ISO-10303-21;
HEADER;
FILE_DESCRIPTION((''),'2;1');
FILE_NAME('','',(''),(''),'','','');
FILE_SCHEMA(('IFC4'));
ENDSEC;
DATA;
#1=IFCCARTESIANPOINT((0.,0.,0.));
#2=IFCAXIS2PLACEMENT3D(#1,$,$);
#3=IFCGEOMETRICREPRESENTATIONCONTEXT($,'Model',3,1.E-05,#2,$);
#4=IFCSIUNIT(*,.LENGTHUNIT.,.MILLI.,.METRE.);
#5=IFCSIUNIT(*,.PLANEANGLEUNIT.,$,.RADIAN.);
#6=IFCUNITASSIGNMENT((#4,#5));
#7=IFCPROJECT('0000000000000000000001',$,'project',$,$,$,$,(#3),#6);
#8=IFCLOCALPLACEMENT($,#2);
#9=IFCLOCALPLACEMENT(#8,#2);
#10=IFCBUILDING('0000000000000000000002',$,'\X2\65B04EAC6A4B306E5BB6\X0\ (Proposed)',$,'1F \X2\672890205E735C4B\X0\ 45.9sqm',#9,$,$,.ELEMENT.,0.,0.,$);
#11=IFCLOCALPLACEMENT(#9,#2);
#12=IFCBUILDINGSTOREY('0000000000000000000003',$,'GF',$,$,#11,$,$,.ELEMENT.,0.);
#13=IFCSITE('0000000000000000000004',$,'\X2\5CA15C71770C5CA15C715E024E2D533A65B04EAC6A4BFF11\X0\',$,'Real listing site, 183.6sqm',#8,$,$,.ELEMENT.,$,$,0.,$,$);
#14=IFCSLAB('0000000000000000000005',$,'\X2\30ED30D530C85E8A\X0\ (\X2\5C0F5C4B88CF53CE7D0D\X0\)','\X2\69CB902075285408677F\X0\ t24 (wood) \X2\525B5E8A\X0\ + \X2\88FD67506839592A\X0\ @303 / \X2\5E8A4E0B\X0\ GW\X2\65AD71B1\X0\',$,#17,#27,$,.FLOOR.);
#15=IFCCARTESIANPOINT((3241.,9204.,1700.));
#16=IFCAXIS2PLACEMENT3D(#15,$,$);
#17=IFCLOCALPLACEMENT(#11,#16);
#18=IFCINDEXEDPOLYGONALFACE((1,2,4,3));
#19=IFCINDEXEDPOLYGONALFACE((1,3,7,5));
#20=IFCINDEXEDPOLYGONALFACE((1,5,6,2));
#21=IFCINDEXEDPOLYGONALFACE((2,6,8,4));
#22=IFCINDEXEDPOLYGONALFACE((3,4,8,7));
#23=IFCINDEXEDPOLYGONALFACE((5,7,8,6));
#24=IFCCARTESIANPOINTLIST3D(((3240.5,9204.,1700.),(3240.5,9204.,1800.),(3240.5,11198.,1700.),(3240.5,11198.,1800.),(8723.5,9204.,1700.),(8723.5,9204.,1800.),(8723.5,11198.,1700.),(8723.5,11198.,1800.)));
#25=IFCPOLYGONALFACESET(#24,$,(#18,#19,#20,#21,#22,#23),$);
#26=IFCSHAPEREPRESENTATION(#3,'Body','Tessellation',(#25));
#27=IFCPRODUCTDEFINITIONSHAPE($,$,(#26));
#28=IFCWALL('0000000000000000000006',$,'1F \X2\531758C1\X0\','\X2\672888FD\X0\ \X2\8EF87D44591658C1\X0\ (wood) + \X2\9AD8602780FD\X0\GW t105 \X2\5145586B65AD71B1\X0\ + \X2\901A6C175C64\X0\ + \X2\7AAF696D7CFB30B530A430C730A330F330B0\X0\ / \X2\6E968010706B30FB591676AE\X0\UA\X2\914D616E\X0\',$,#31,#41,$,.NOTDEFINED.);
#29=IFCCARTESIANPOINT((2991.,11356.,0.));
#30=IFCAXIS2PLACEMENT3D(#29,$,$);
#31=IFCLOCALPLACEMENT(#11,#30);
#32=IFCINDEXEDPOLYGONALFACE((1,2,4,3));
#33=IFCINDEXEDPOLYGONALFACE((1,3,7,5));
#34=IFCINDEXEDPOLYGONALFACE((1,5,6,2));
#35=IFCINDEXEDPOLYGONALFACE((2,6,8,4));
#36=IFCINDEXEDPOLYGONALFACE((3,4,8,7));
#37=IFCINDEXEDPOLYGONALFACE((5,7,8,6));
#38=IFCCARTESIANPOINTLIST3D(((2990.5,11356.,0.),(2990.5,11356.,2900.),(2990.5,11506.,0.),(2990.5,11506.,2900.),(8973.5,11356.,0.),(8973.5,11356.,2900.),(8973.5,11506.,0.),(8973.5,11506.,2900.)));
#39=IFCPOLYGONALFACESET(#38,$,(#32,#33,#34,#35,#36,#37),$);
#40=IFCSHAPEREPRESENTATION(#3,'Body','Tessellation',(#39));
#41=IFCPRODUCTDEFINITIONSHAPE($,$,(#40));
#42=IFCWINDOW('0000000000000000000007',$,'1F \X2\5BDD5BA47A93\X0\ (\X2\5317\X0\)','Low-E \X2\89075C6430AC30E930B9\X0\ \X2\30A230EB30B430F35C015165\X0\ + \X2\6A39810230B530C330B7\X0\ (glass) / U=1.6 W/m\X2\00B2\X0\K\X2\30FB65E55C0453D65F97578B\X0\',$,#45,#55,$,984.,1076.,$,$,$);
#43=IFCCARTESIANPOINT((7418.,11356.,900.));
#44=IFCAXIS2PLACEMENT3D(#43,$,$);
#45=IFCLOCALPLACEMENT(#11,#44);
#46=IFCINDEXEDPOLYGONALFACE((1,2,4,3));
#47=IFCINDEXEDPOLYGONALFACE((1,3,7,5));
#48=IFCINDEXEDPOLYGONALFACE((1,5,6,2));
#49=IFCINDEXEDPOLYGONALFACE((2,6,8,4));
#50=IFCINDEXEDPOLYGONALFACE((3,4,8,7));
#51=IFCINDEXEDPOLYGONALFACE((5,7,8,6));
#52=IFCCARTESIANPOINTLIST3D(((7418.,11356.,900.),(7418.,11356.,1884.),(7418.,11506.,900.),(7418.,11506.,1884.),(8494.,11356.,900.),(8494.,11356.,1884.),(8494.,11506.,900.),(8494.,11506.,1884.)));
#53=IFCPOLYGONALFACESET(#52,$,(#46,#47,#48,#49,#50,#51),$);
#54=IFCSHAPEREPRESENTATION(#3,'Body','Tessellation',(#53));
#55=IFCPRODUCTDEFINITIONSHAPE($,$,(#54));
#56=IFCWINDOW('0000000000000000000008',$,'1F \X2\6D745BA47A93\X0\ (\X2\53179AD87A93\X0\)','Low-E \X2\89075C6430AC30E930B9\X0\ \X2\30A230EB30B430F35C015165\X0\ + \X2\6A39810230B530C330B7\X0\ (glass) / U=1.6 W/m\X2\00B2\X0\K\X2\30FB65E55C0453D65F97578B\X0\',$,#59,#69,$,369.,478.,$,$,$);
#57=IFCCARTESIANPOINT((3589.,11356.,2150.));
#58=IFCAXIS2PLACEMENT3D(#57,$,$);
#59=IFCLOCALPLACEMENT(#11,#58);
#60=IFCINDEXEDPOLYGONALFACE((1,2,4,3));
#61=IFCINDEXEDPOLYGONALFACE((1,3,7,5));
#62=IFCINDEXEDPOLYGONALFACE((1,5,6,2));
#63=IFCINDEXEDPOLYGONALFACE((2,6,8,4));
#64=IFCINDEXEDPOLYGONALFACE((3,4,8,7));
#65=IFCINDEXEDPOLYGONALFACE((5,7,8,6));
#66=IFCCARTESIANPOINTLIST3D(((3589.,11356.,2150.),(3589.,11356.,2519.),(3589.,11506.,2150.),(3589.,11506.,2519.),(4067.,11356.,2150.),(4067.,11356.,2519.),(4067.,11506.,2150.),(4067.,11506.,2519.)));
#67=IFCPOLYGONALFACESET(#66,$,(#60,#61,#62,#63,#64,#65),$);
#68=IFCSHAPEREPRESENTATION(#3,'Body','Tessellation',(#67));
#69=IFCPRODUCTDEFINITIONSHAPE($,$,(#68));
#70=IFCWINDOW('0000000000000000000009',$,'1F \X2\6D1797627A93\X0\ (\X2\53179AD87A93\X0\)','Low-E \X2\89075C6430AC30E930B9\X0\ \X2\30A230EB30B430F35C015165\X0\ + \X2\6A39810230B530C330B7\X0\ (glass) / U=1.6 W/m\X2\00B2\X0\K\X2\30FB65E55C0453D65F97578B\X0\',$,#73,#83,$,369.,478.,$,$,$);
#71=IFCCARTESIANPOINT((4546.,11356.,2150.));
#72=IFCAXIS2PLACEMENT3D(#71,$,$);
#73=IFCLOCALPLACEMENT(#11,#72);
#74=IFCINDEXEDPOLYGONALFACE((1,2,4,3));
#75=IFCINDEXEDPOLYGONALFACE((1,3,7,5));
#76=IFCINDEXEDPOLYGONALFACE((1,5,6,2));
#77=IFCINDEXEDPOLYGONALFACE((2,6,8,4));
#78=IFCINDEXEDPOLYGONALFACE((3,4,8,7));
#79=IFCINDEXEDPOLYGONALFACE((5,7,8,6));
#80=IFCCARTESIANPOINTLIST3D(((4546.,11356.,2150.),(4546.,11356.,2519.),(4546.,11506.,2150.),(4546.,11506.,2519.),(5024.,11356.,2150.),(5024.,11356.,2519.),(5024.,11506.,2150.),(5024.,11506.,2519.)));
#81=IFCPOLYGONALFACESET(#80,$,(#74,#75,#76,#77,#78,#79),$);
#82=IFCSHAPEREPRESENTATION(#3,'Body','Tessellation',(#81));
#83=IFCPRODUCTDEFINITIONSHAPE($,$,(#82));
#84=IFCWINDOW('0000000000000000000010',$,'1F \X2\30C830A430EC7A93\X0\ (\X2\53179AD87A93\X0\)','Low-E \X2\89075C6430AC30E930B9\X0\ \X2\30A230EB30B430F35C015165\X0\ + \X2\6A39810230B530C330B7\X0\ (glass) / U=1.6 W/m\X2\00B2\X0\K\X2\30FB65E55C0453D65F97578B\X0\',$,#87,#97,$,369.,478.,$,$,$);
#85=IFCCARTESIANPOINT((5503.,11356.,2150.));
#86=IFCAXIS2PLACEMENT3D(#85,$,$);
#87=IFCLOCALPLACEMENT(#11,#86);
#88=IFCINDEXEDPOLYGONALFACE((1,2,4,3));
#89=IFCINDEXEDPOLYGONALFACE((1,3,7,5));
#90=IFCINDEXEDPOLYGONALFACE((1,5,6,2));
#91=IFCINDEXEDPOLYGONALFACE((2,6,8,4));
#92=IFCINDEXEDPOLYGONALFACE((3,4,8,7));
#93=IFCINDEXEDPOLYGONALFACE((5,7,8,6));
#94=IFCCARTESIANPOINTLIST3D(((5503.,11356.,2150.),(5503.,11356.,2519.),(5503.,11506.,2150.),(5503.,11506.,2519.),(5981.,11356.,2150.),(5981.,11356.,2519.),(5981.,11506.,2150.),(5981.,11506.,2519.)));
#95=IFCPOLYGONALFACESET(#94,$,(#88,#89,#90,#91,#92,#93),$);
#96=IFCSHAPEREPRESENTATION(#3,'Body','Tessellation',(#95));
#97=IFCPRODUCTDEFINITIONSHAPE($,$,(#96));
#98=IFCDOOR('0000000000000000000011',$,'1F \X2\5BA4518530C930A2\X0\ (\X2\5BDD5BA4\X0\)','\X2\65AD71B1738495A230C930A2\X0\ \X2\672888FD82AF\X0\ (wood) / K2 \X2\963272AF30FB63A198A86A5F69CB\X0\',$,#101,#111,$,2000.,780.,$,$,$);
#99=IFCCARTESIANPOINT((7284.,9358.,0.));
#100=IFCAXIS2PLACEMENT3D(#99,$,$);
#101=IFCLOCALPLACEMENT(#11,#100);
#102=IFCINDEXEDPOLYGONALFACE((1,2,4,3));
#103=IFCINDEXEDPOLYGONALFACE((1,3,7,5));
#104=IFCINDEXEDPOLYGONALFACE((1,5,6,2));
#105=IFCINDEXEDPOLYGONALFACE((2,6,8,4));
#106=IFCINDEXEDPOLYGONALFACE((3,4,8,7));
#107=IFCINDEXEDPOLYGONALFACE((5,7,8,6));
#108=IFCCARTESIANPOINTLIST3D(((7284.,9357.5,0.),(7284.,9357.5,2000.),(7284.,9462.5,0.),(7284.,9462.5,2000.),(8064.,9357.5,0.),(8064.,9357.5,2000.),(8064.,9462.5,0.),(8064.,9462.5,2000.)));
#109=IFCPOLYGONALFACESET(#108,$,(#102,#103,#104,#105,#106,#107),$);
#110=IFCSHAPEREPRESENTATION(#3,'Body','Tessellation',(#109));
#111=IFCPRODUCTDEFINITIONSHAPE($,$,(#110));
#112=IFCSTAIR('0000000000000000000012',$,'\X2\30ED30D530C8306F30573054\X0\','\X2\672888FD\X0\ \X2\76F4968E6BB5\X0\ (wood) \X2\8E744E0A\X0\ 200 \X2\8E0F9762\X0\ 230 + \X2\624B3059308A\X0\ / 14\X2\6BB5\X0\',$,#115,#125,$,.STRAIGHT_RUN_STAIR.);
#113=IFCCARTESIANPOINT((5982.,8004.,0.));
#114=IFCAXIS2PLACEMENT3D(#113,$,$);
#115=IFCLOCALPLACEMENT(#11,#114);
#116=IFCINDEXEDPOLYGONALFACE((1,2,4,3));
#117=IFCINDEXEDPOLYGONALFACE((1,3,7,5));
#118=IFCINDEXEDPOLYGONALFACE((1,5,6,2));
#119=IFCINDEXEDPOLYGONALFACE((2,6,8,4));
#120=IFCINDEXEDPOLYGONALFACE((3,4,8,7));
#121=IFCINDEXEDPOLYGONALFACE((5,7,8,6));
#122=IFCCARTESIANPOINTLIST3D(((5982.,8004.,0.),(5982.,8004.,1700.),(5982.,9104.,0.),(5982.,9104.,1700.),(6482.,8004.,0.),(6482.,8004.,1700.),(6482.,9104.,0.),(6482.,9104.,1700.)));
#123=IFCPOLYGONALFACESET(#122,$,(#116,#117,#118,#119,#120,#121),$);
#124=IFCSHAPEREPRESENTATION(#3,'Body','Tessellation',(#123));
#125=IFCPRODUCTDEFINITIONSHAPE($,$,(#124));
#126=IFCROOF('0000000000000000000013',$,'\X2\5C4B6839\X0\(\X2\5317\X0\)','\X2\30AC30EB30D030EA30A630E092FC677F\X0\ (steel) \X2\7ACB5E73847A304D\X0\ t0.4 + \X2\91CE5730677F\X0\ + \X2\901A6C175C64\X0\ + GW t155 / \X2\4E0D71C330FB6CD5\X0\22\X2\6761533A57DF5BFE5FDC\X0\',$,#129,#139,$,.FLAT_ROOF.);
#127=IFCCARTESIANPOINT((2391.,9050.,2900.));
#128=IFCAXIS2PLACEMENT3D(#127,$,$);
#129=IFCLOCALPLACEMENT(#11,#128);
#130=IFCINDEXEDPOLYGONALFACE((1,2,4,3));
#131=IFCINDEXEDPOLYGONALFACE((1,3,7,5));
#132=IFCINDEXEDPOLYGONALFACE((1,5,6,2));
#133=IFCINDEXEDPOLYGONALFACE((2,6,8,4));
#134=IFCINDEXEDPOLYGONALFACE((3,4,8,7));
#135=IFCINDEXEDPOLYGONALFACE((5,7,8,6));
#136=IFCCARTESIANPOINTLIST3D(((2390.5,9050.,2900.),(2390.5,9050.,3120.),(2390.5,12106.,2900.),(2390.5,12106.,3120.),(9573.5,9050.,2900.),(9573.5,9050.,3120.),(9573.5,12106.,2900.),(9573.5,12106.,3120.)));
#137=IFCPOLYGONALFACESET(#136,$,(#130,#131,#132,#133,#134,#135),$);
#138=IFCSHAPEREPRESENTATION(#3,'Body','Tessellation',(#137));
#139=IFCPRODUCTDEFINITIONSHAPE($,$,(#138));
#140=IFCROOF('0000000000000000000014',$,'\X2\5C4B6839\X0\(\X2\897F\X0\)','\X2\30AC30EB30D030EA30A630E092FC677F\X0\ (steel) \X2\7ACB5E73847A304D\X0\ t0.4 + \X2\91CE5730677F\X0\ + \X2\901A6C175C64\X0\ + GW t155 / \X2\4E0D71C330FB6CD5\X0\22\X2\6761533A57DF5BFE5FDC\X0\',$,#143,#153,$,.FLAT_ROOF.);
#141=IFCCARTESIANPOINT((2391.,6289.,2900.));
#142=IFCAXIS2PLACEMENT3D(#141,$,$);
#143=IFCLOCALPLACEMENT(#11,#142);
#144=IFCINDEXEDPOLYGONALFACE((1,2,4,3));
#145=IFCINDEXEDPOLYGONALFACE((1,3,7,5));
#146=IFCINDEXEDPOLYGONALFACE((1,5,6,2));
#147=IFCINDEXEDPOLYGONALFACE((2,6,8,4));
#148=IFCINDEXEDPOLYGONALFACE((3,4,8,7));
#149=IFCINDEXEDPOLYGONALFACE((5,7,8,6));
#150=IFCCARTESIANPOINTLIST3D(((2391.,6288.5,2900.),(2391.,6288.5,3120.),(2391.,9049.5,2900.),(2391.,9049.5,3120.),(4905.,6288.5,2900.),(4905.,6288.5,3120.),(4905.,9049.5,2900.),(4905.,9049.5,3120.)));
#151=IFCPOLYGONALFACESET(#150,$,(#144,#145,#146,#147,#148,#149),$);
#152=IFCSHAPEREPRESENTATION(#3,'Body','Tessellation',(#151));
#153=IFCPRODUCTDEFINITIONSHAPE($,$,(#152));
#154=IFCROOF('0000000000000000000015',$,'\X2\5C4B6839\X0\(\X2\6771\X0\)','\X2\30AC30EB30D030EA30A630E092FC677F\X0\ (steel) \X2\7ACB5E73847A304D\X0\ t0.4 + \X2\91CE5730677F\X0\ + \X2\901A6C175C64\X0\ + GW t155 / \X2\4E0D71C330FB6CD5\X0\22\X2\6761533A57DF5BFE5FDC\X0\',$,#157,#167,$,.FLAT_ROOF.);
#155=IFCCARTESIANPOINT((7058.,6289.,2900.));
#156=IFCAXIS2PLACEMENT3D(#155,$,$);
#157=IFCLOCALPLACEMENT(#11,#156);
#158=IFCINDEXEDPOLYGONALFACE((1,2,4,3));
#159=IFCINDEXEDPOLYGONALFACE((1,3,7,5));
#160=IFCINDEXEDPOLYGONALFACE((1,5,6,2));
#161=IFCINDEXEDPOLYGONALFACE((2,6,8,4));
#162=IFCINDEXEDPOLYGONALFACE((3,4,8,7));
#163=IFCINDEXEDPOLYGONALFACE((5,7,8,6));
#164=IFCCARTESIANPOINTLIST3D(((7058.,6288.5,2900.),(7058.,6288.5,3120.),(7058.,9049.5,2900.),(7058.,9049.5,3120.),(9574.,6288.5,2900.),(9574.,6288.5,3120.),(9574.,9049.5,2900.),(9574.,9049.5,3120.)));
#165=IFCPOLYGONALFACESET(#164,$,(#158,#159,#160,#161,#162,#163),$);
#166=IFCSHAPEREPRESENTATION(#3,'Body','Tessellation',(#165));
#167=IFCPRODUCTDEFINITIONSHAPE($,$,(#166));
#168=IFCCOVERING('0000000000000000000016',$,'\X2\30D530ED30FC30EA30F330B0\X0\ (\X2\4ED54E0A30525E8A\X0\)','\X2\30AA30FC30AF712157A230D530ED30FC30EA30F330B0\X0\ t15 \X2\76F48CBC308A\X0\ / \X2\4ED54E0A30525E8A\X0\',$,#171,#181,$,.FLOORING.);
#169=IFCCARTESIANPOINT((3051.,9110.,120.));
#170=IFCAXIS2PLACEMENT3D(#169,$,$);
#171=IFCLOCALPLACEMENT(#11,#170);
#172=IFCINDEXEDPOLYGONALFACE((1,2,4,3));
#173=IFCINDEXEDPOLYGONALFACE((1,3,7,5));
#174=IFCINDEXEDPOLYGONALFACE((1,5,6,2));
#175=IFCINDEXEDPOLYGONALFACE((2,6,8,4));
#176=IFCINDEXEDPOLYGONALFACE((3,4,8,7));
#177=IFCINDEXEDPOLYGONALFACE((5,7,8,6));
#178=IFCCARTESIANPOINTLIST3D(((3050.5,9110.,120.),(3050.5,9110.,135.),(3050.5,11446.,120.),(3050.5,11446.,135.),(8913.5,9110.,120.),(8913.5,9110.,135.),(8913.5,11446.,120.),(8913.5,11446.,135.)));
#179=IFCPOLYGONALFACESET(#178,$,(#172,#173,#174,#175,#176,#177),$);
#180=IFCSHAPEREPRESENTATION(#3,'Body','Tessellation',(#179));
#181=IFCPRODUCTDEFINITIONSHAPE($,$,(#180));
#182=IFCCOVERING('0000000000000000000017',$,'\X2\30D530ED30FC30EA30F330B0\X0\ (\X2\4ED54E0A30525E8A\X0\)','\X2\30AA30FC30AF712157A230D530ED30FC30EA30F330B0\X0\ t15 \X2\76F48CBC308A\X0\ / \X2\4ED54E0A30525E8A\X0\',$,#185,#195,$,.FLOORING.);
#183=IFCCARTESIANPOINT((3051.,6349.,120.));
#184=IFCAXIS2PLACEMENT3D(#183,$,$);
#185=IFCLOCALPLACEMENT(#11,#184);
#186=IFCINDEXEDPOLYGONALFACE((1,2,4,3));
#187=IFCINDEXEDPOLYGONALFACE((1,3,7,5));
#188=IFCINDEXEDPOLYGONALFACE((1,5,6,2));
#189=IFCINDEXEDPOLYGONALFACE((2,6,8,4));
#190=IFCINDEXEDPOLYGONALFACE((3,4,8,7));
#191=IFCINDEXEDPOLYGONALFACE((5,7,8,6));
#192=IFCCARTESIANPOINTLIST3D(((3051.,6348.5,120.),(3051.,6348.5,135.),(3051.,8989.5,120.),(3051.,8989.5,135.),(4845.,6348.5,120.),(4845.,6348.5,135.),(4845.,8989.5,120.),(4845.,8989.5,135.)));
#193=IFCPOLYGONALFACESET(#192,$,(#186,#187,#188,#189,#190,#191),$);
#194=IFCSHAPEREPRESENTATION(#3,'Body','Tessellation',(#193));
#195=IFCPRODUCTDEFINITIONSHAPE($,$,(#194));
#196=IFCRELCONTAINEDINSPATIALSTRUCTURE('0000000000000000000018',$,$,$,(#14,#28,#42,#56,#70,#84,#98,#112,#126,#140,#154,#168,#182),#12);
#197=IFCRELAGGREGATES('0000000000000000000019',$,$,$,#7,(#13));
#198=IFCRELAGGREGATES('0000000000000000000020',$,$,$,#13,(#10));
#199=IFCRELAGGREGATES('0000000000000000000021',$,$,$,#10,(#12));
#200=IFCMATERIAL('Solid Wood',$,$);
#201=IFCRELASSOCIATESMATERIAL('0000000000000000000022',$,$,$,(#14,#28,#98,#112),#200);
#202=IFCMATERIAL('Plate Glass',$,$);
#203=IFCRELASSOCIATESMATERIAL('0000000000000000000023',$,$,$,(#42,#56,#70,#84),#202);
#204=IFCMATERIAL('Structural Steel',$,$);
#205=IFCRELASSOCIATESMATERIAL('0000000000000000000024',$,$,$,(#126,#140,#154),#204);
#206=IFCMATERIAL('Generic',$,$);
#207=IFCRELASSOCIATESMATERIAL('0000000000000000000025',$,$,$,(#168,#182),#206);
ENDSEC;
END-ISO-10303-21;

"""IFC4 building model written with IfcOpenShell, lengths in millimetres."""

from ifc_helpers import new_model, si_unit, frame, frame_2d, origin, place, context, project, spatial, rectangle, extrude, material, element, fill, save


model = new_model("IFC4")

# Units and contexts
model_context = context("Model", 3, precision=1e-05, world=origin())
ifc_project = project(units=[si_unit("LENGTHUNIT", "METRE", prefix="MILLI"), si_unit("PLANEANGLEUNIT", "RADIAN")], contexts=[model_context])

# Site, building, storey
site_placement = place(None, origin())
site = spatial("IfcSite", under=ifc_project, at=site_placement, Name="岡山県岡山市中区新京橋１", ObjectType="Real listing site, 183.6sqm", CompositionType="ELEMENT", RefElevation=0.0)
building_placement = place(site_placement, origin())
building = spatial("IfcBuilding", under=site, at=building_placement, Name="新京橋の家 (Proposed)", ObjectType="1F 木造平屋 45.9sqm", CompositionType="ELEMENT", ElevationOfRefHeight=0.0, ElevationOfTerrain=0.0)
storey_placement = place(building_placement, origin())
storey = spatial("IfcBuildingStorey", under=building, at=storey_placement, Name="GF", CompositionType="ELEMENT", Elevation=0.0)

# Slab
ifc_material_1 = material(Name="Solid Wood")
slab_1_placement = place(storey_placement, frame((3241.0, 9204.0, 1700.0)))
element("IfcSlab", 1, at=slab_1_placement, inside=storey, material=ifc_material_1, Name="ロフト床 (小屋裏収納)", Description="構造用合板 t24 (wood) 剛床 + 製材根太 @303 / 床下 GW断熱", PredefinedType="FLOOR", context=model_context, shape_type="SweptSolid", body=[
    extrude(rectangle(XDim=5483.0, YDim=1994.0, at=frame_2d((2741.0, 997.0))), frame((3241.0, 9204.0, 1700.0)), (0.0, 0.0, 1.0), 100.0),
])

# Wall, openings, windows
wall_1_placement = place(storey_placement, frame((2991.0, 11356.0, 0.0)))
wall_1 = element("IfcWall", 2, at=wall_1_placement, inside=storey, material=ifc_material_1, Name="1F 北壁", Description="木製 軸組外壁 (wood) + 高性能GW t105 充填断熱 + 通気層 + 窯業系サイディング / 準耐火・外皮UA配慮", PredefinedType="NOTDEFINED", context=model_context, shape_type="SweptSolid", body=[
    extrude(rectangle(XDim=5983.0, YDim=150.0, at=frame_2d((2991.0, 75.0))), frame((2991.0, 11356.0, 0.0)), (0.0, 0.0, 1.0), 2900.0),
])
opening_1_placement = place(storey_placement, frame((7418.0, 11356.0, 900.0)))
opening_1 = element("IfcOpeningElement", 3, at=opening_1_placement, cuts=wall_1, PredefinedType="NOTDEFINED", context=model_context, shape_type="SweptSolid", body=[
    extrude(rectangle(XDim=1076.0, YDim=150.0, at=frame_2d((538.0, 75.0))), frame((7418.0, 11356.0, 900.0)), (0.0, 0.0, 1.0), 984.0),
])
opening_2_placement = place(storey_placement, frame((3589.0, 11356.0, 2150.0)))
opening_2 = element("IfcOpeningElement", 4, at=opening_2_placement, cuts=wall_1, PredefinedType="NOTDEFINED", context=model_context, shape_type="SweptSolid", body=[
    extrude(rectangle(XDim=478.0, YDim=150.0, at=frame_2d((239.0, 75.0))), frame((3589.0, 11356.0, 2150.0)), (0.0, 0.0, 1.0), 369.0),
])
opening_3_placement = place(storey_placement, frame((4546.0, 11356.0, 2150.0)))
opening_3 = element("IfcOpeningElement", 5, at=opening_3_placement, cuts=wall_1, PredefinedType="NOTDEFINED", context=model_context, shape_type="SweptSolid", body=[
    extrude(rectangle(XDim=478.0, YDim=150.0, at=frame_2d((239.0, 75.0))), frame((4546.0, 11356.0, 2150.0)), (0.0, 0.0, 1.0), 369.0),
])
opening_4_placement = place(storey_placement, frame((5503.0, 11356.0, 2150.0)))
opening_4 = element("IfcOpeningElement", 6, at=opening_4_placement, cuts=wall_1, PredefinedType="NOTDEFINED", context=model_context, shape_type="SweptSolid", body=[
    extrude(rectangle(XDim=478.0, YDim=150.0, at=frame_2d((239.0, 75.0))), frame((5503.0, 11356.0, 2150.0)), (0.0, 0.0, 1.0), 369.0),
])
ifc_material_2 = material(Name="Plate Glass")
window_1_placement = place(storey_placement, frame((7418.0, 11356.0, 900.0)))
window_1 = element("IfcWindow", 7, at=window_1_placement, inside=storey, material=ifc_material_2, Name="1F 寝室窓 (北)", Description="Low-E 複層ガラス アルゴン封入 + 樹脂サッシ (glass) / U=1.6 W/m²K・日射取得型", OverallHeight=984.0, OverallWidth=1076.0, context=model_context, shape_type="SweptSolid", body=[
    extrude(rectangle(XDim=1076.0, YDim=150.0, at=frame_2d((538.0, 75.0))), frame((7418.0, 11356.0, 900.0)), (0.0, 0.0, 1.0), 984.0),
])
fill(opening_1, window_1)
window_2_placement = place(storey_placement, frame((3589.0, 11356.0, 2150.0)))
window_2 = element("IfcWindow", 8, at=window_2_placement, inside=storey, material=ifc_material_2, Name="1F 浴室窓 (北高窓)", Description="Low-E 複層ガラス アルゴン封入 + 樹脂サッシ (glass) / U=1.6 W/m²K・日射取得型", OverallHeight=369.0, OverallWidth=478.0, context=model_context, shape_type="SweptSolid", body=[
    extrude(rectangle(XDim=478.0, YDim=150.0, at=frame_2d((239.0, 75.0))), frame((3589.0, 11356.0, 2150.0)), (0.0, 0.0, 1.0), 369.0),
])
fill(opening_2, window_2)
window_3_placement = place(storey_placement, frame((4546.0, 11356.0, 2150.0)))
window_3 = element("IfcWindow", 9, at=window_3_placement, inside=storey, material=ifc_material_2, Name="1F 洗面窓 (北高窓)", Description="Low-E 複層ガラス アルゴン封入 + 樹脂サッシ (glass) / U=1.6 W/m²K・日射取得型", OverallHeight=369.0, OverallWidth=478.0, context=model_context, shape_type="SweptSolid", body=[
    extrude(rectangle(XDim=478.0, YDim=150.0, at=frame_2d((239.0, 75.0))), frame((4546.0, 11356.0, 2150.0)), (0.0, 0.0, 1.0), 369.0),
])
fill(opening_3, window_3)
window_4_placement = place(storey_placement, frame((5503.0, 11356.0, 2150.0)))
window_4 = element("IfcWindow", 10, at=window_4_placement, inside=storey, material=ifc_material_2, Name="1F トイレ窓 (北高窓)", Description="Low-E 複層ガラス アルゴン封入 + 樹脂サッシ (glass) / U=1.6 W/m²K・日射取得型", OverallHeight=369.0, OverallWidth=478.0, context=model_context, shape_type="SweptSolid", body=[
    extrude(rectangle(XDim=478.0, YDim=150.0, at=frame_2d((239.0, 75.0))), frame((5503.0, 11356.0, 2150.0)), (0.0, 0.0, 1.0), 369.0),
])
fill(opening_4, window_4)

# Door
door_1_placement = place(storey_placement, frame((7284.0, 9358.0, 0.0)))
element("IfcDoor", 11, at=door_1_placement, inside=storey, material=ifc_material_1, Name="1F 室内ドア (寝室)", Description="断熱玄関ドア 木製芯 (wood) / K2 防犯・採風機構", OverallHeight=2000.0, OverallWidth=780.0, context=model_context, shape_type="SweptSolid", body=[
    extrude(rectangle(XDim=780.0, YDim=105.0, at=frame_2d((390.0, 52.0))), frame((7284.0, 9358.0, 0.0)), (0.0, 0.0, 1.0), 2000.0),
])

# Stair
stair_placement = place(storey_placement, frame((5982.0, 8004.0, 0.0)))
element("IfcStair", 12, at=stair_placement, inside=storey, material=ifc_material_1, Name="ロフトはしご", Description="木製 直階段 (wood) 蹴上 200 踏面 230 + 手すり / 14段", PredefinedType="STRAIGHT_RUN_STAIR", context=model_context, shape_type="SweptSolid", body=[
    extrude(rectangle(XDim=500.0, YDim=1100.0, at=frame_2d((250.0, 550.0))), frame((5982.0, 8004.0, 0.0)), (0.0, 0.0, 1.0), 1700.0),
])

# Roofs
ifc_material_3 = material(Name="Structural Steel")
roof_1_placement = place(storey_placement, frame((2391.0, 9050.0, 2900.0)))
element("IfcRoof", 13, at=roof_1_placement, inside=storey, material=ifc_material_3, Name="屋根(北)", Description="ガルバリウム鋼板 (steel) 立平葺き t0.4 + 野地板 + 通気層 + GW t155 / 不燃・法22条区域対応", PredefinedType="FLAT_ROOF", context=model_context, shape_type="SweptSolid", body=[
    extrude(rectangle(XDim=7183.0, YDim=3056.0, at=frame_2d((3591.0, 1528.0))), frame((2391.0, 9050.0, 2900.0)), (0.0, 0.0, 1.0), 220.0),
])
roof_2_placement = place(storey_placement, frame((2391.0, 6289.0, 2900.0)))
element("IfcRoof", 14, at=roof_2_placement, inside=storey, material=ifc_material_3, Name="屋根(西)", Description="ガルバリウム鋼板 (steel) 立平葺き t0.4 + 野地板 + 通気層 + GW t155 / 不燃・法22条区域対応", PredefinedType="FLAT_ROOF", context=model_context, shape_type="SweptSolid", body=[
    extrude(rectangle(XDim=2514.0, YDim=2761.0, at=frame_2d((1257.0, 1380.0))), frame((2391.0, 6289.0, 2900.0)), (0.0, 0.0, 1.0), 220.0),
])
roof_3_placement = place(storey_placement, frame((7058.0, 6289.0, 2900.0)))
element("IfcRoof", 15, at=roof_3_placement, inside=storey, material=ifc_material_3, Name="屋根(東)", Description="ガルバリウム鋼板 (steel) 立平葺き t0.4 + 野地板 + 通気層 + GW t155 / 不燃・法22条区域対応", PredefinedType="FLAT_ROOF", context=model_context, shape_type="SweptSolid", body=[
    extrude(rectangle(XDim=2516.0, YDim=2761.0, at=frame_2d((1258.0, 1380.0))), frame((7058.0, 6289.0, 2900.0)), (0.0, 0.0, 1.0), 220.0),
])

# Coverings
ifc_material_4 = material(Name="Generic")
covering_1_placement = place(storey_placement, frame((3051.0, 9110.0, 120.0)))
element("IfcCovering", 16, at=covering_1_placement, inside=storey, material=ifc_material_4, Name="フローリング (仕上げ床)", Description="オーク無垢フローリング t15 直貼り / 仕上げ床", PredefinedType="FLOORING", context=model_context, shape_type="SweptSolid", body=[
    extrude(rectangle(XDim=5863.0, YDim=2336.0, at=frame_2d((2931.0, 1168.0))), frame((3051.0, 9110.0, 120.0)), (0.0, 0.0, 1.0), 15.0),
])
covering_2_placement = place(storey_placement, frame((3051.0, 6349.0, 120.0)))
element("IfcCovering", 17, at=covering_2_placement, inside=storey, material=ifc_material_4, Name="フローリング (仕上げ床)", Description="オーク無垢フローリング t15 直貼り / 仕上げ床", PredefinedType="FLOORING", context=model_context, shape_type="SweptSolid", body=[
    extrude(rectangle(XDim=1794.0, YDim=2641.0, at=frame_2d((897.0, 1320.0))), frame((3051.0, 6349.0, 120.0)), (0.0, 0.0, 1.0), 15.0),
])

save(model, "model.ifc")
